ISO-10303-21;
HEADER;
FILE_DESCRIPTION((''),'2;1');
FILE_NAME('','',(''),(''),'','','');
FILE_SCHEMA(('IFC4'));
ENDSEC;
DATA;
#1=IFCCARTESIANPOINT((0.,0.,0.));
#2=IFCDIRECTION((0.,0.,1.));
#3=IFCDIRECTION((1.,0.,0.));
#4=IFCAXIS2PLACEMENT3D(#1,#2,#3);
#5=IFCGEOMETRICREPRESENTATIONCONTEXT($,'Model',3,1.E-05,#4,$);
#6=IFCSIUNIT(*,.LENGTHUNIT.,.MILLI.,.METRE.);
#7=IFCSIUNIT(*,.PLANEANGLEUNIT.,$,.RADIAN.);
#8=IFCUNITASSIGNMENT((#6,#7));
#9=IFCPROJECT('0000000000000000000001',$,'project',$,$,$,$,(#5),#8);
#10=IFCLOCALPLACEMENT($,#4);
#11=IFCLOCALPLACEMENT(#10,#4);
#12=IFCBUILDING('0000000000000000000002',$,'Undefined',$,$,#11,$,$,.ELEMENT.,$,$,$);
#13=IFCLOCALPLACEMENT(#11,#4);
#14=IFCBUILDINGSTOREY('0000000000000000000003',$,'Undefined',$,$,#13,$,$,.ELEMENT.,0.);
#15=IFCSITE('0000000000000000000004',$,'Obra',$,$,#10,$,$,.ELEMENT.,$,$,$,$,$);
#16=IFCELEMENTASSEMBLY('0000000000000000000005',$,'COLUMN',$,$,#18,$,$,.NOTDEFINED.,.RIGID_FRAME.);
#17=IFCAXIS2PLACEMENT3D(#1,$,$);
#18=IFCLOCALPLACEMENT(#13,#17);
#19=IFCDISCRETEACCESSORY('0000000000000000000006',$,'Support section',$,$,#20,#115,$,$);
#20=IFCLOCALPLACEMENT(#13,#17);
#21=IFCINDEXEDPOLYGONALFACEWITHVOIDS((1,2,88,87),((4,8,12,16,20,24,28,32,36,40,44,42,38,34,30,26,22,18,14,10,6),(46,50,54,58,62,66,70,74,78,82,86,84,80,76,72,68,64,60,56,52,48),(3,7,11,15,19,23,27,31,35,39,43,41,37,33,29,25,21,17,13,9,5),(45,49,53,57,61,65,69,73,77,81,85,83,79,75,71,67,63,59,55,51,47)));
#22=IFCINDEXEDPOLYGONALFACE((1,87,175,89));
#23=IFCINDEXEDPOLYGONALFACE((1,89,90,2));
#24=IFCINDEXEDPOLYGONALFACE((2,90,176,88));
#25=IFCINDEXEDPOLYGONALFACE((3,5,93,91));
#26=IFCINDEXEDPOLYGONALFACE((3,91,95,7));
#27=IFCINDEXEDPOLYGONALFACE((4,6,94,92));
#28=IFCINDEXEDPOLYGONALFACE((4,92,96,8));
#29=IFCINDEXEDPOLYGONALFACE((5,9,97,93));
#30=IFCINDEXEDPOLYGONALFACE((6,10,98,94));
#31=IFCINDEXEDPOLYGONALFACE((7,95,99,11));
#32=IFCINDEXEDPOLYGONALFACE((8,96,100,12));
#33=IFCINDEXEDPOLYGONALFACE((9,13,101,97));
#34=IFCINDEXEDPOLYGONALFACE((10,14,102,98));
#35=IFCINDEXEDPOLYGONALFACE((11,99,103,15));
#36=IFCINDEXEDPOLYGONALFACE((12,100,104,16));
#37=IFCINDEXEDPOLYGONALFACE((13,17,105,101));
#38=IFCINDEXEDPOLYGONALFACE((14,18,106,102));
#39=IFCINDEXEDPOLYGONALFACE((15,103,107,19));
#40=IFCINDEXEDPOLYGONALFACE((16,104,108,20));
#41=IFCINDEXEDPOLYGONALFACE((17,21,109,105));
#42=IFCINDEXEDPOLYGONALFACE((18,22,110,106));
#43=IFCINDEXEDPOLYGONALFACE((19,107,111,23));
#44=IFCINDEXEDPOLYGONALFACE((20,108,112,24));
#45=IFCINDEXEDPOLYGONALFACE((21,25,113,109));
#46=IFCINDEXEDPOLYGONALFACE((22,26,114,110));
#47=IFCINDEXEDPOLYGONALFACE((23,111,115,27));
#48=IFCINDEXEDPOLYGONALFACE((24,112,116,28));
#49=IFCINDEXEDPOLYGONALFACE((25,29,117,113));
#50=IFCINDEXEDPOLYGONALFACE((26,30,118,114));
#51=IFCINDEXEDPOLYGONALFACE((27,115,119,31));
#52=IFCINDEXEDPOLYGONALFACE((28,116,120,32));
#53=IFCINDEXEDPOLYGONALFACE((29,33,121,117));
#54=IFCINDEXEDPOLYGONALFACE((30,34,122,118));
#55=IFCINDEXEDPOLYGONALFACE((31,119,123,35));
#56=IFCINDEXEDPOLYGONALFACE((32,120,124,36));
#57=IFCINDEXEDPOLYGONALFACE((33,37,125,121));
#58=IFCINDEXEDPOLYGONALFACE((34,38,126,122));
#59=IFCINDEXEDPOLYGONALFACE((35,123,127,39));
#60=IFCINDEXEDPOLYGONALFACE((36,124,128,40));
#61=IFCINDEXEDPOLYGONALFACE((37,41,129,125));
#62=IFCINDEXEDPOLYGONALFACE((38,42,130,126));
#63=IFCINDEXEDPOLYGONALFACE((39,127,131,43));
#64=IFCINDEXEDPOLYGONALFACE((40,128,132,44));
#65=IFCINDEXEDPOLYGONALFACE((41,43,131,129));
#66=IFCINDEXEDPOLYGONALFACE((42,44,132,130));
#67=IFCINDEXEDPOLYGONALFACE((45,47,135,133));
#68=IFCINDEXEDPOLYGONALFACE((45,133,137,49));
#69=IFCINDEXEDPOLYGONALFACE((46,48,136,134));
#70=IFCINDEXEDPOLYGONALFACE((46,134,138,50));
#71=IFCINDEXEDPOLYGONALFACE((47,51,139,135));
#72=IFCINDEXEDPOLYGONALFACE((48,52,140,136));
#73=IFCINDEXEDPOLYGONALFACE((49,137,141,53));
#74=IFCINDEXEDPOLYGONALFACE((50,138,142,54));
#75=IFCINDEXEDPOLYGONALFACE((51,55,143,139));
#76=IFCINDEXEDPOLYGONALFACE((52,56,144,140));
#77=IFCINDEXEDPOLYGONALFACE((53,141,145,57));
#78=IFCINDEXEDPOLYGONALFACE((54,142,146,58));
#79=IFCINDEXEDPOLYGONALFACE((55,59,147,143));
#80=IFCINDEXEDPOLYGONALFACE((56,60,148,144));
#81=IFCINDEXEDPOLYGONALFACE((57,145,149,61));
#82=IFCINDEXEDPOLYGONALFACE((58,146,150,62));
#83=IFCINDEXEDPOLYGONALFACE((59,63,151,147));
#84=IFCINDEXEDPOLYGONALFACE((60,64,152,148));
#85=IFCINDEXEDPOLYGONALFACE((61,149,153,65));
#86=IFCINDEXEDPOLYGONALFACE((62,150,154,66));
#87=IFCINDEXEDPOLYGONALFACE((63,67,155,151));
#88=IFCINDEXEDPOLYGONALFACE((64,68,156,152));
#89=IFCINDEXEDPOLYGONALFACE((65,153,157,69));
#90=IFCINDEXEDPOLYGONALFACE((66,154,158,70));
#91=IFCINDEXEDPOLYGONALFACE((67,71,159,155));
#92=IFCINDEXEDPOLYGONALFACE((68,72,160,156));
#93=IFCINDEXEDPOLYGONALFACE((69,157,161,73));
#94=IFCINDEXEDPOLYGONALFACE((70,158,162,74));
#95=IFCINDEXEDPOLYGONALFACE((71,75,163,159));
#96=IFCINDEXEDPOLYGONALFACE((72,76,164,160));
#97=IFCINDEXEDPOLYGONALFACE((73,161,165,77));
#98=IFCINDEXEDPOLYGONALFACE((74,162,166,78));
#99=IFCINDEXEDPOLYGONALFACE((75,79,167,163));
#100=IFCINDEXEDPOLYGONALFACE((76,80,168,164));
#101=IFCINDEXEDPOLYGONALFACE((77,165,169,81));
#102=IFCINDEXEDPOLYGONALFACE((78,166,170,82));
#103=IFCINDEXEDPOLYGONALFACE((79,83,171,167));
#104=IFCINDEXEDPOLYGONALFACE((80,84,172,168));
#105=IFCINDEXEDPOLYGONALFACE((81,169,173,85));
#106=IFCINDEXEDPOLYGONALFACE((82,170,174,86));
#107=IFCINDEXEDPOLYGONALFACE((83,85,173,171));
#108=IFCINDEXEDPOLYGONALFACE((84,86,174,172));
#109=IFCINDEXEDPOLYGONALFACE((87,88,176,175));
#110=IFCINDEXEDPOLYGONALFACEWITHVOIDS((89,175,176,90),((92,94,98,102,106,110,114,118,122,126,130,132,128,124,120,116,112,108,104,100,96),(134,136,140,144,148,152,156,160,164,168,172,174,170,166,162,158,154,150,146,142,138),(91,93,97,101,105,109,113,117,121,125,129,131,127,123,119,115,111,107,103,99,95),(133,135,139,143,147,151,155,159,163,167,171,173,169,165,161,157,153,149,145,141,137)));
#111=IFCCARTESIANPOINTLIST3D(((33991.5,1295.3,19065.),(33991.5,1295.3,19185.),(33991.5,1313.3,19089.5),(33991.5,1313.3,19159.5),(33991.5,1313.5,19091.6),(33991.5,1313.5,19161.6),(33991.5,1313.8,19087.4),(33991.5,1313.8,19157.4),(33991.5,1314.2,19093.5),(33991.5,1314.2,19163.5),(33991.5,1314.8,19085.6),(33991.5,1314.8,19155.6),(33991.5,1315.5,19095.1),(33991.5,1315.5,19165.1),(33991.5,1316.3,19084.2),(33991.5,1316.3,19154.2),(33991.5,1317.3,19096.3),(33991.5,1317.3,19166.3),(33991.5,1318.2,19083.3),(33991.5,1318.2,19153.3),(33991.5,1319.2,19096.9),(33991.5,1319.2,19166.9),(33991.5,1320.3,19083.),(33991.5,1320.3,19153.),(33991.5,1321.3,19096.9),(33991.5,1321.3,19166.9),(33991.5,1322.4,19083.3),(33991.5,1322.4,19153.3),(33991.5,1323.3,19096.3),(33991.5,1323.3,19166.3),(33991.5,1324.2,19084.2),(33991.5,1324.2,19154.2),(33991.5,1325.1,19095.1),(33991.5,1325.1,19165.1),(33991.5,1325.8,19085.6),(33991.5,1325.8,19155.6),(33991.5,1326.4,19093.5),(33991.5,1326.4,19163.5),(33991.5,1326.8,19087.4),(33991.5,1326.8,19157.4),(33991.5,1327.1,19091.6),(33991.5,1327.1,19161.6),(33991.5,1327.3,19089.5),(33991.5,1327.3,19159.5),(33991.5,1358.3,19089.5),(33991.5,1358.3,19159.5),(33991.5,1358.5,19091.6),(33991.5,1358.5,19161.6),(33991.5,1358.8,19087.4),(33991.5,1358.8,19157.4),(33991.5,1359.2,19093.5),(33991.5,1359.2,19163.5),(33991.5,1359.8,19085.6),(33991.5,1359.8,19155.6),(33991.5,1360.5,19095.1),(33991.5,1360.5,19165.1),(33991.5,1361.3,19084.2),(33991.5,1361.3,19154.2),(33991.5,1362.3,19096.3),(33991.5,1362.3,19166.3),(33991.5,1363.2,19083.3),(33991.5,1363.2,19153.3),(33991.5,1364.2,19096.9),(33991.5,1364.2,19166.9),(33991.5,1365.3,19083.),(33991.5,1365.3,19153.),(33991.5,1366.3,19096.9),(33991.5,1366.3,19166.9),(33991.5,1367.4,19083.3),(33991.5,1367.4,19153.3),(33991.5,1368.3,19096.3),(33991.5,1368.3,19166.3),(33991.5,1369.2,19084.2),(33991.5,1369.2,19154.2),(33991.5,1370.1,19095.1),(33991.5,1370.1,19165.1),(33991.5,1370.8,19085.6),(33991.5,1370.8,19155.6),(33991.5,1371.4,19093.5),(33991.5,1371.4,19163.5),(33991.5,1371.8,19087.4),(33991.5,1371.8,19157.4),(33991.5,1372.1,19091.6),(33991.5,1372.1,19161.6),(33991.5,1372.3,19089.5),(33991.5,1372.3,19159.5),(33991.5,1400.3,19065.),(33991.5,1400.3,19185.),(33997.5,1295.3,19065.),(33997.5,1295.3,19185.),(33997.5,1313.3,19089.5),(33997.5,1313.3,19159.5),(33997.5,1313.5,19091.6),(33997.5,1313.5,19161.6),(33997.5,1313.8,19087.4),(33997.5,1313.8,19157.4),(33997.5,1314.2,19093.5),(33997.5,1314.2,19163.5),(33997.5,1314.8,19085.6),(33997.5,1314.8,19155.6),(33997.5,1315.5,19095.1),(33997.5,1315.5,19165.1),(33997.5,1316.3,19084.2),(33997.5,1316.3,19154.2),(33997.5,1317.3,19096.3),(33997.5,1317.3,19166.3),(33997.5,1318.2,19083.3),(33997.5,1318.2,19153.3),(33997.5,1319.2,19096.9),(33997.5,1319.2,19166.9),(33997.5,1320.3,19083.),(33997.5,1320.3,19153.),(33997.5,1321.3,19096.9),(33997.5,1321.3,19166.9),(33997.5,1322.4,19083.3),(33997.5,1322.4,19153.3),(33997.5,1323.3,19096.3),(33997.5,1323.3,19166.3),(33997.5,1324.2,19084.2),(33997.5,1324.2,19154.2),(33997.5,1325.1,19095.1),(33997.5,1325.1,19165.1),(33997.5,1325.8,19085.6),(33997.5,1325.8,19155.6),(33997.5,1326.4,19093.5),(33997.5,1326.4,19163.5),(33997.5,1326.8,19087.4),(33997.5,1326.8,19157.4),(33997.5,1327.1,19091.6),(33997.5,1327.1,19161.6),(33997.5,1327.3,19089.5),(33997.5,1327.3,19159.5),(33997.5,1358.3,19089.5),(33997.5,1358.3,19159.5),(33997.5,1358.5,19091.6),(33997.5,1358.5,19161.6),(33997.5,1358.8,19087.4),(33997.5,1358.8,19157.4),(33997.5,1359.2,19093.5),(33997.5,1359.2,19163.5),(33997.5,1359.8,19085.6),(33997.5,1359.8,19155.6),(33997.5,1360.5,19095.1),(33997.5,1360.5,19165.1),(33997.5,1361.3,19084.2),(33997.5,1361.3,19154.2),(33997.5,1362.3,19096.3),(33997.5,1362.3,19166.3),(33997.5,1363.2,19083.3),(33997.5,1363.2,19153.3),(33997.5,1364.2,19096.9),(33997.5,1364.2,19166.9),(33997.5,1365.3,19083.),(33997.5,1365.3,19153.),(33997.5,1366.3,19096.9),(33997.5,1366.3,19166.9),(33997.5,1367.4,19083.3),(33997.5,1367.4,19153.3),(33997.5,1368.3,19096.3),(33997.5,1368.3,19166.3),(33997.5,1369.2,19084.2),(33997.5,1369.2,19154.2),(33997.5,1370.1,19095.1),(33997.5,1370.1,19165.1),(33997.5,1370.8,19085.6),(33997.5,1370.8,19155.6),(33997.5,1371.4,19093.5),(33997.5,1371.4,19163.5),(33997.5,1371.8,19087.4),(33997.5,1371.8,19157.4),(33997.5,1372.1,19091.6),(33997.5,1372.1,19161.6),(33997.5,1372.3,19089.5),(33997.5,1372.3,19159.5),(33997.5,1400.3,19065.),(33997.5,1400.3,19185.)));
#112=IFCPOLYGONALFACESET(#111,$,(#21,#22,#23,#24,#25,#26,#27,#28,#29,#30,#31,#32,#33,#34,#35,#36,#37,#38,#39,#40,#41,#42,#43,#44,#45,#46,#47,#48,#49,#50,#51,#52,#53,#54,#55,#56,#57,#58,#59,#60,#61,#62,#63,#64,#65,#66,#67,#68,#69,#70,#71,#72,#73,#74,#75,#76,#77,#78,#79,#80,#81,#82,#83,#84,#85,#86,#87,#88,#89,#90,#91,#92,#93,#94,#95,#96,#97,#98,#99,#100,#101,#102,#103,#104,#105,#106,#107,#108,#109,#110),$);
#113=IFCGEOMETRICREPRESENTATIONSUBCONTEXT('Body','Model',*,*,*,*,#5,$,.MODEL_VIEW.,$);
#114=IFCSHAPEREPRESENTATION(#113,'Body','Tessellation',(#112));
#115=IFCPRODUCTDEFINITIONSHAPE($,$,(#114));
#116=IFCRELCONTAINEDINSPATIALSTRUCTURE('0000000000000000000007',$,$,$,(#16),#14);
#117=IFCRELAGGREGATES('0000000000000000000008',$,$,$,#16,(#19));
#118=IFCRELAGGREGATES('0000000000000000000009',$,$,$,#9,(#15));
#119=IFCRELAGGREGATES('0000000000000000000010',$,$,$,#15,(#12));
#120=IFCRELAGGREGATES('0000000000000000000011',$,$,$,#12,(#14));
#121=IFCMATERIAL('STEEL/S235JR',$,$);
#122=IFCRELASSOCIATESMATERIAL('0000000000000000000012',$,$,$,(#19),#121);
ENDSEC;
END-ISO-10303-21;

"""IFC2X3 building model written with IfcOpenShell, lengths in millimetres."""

from ifc_helpers import new_model, si_unit, frame, origin_with_axes, origin_2d_with_axis, place, context, subcontext, project, spatial, rectangle, circle, extrude, source, transform, mapped, material, element, aggregate, save


model = new_model("IFC2X3")

# Units and contexts
model_context = context("Model", 3, precision=1e-05, world=origin_with_axes())
body_context = subcontext(model_context, "Body", "Model", "MODEL_VIEW")
ifc_project = project(units=[si_unit("LENGTHUNIT", "METRE", prefix="MILLI"), si_unit("PLANEANGLEUNIT", "RADIAN")], contexts=[model_context])

# Site, building, storey
site_placement = place(None, origin_with_axes())
site = spatial("IfcSite", under=ifc_project, at=site_placement, Name="Obra", CompositionType="ELEMENT")
building_placement = place(site_placement, origin_with_axes())
building = spatial("IfcBuilding", under=site, at=building_placement, Name="Undefined", CompositionType="ELEMENT")
storey_placement = place(building_placement, origin_with_axes())
storey = spatial("IfcBuildingStorey", under=building, at=storey_placement, Name="Undefined", CompositionType="ELEMENT", Elevation=0.0)

# Element assembly, discrete accessory, opening
assembly_1_placement = place(storey_placement, origin_with_axes())
assembly_1 = element("IfcElementAssembly", 1, at=assembly_1_placement, inside=storey, Name="COLUMN", AssemblyPlace="NOTDEFINED", PredefinedType="RIGID_FRAME")
ifc_material_1 = material(Name="STEEL/S235JR")
shared_shape_1 = source(origin_with_axes(), body_context, "Body", "SweptSolid", [
    extrude(circle(Radius=7.0, at=origin_2d_with_axis()), frame((0.0, -8.6, 0.0), z_axis=(0.0, 1.0, 0.0), x_axis=(1.0, 0.0, 0.0)), (0.0, 0.0, 1.0), 6.2),
])
discrete_accessory_1_placement = place(assembly_1_placement, frame((33994.5, 1347.8, 19065.0), z_axis=(0.0, 0.0, 1.0), x_axis=(0.0, 1.0, 0.0)))
discrete_accessory_1 = element("IfcDiscreteAccessory", 2, at=discrete_accessory_1_placement, material=ifc_material_1, Name="Support section", context=body_context, shape_type="SweptSolid", body=[
    extrude(rectangle(XDim=6.0, YDim=105.0, at=origin_2d_with_axis()), frame((0.0, 0.0, 120.0), z_axis=(0.0, 0.0, -1.0), x_axis=(0.0, 1.0, 0.0)), (0.0, 0.0, 1.0), 120.0),
])
opening_1_placement = place(assembly_1_placement, frame((34000.0, 1390.3, 19205.0), z_axis=(0.0, -1.0, 0.0), x_axis=(0.0, 0.0, -1.0)))
element("IfcOpeningElement", 3, at=opening_1_placement, cuts=discrete_accessory_1, ObjectType="Opening", context=body_context, shape_type="MappedRepresentation", body=[
    mapped(shared_shape_1, transform((45.0, 0.0, 25.0))),
    mapped(shared_shape_1, transform((45.0, 0.0, 70.0))),
    mapped(shared_shape_1, transform((115.0, 0.0, 25.0))),
    mapped(shared_shape_1, transform((115.0, 0.0, 70.0))),
])
aggregate(assembly_1, [discrete_accessory_1])

save(model, "model.ifc")
